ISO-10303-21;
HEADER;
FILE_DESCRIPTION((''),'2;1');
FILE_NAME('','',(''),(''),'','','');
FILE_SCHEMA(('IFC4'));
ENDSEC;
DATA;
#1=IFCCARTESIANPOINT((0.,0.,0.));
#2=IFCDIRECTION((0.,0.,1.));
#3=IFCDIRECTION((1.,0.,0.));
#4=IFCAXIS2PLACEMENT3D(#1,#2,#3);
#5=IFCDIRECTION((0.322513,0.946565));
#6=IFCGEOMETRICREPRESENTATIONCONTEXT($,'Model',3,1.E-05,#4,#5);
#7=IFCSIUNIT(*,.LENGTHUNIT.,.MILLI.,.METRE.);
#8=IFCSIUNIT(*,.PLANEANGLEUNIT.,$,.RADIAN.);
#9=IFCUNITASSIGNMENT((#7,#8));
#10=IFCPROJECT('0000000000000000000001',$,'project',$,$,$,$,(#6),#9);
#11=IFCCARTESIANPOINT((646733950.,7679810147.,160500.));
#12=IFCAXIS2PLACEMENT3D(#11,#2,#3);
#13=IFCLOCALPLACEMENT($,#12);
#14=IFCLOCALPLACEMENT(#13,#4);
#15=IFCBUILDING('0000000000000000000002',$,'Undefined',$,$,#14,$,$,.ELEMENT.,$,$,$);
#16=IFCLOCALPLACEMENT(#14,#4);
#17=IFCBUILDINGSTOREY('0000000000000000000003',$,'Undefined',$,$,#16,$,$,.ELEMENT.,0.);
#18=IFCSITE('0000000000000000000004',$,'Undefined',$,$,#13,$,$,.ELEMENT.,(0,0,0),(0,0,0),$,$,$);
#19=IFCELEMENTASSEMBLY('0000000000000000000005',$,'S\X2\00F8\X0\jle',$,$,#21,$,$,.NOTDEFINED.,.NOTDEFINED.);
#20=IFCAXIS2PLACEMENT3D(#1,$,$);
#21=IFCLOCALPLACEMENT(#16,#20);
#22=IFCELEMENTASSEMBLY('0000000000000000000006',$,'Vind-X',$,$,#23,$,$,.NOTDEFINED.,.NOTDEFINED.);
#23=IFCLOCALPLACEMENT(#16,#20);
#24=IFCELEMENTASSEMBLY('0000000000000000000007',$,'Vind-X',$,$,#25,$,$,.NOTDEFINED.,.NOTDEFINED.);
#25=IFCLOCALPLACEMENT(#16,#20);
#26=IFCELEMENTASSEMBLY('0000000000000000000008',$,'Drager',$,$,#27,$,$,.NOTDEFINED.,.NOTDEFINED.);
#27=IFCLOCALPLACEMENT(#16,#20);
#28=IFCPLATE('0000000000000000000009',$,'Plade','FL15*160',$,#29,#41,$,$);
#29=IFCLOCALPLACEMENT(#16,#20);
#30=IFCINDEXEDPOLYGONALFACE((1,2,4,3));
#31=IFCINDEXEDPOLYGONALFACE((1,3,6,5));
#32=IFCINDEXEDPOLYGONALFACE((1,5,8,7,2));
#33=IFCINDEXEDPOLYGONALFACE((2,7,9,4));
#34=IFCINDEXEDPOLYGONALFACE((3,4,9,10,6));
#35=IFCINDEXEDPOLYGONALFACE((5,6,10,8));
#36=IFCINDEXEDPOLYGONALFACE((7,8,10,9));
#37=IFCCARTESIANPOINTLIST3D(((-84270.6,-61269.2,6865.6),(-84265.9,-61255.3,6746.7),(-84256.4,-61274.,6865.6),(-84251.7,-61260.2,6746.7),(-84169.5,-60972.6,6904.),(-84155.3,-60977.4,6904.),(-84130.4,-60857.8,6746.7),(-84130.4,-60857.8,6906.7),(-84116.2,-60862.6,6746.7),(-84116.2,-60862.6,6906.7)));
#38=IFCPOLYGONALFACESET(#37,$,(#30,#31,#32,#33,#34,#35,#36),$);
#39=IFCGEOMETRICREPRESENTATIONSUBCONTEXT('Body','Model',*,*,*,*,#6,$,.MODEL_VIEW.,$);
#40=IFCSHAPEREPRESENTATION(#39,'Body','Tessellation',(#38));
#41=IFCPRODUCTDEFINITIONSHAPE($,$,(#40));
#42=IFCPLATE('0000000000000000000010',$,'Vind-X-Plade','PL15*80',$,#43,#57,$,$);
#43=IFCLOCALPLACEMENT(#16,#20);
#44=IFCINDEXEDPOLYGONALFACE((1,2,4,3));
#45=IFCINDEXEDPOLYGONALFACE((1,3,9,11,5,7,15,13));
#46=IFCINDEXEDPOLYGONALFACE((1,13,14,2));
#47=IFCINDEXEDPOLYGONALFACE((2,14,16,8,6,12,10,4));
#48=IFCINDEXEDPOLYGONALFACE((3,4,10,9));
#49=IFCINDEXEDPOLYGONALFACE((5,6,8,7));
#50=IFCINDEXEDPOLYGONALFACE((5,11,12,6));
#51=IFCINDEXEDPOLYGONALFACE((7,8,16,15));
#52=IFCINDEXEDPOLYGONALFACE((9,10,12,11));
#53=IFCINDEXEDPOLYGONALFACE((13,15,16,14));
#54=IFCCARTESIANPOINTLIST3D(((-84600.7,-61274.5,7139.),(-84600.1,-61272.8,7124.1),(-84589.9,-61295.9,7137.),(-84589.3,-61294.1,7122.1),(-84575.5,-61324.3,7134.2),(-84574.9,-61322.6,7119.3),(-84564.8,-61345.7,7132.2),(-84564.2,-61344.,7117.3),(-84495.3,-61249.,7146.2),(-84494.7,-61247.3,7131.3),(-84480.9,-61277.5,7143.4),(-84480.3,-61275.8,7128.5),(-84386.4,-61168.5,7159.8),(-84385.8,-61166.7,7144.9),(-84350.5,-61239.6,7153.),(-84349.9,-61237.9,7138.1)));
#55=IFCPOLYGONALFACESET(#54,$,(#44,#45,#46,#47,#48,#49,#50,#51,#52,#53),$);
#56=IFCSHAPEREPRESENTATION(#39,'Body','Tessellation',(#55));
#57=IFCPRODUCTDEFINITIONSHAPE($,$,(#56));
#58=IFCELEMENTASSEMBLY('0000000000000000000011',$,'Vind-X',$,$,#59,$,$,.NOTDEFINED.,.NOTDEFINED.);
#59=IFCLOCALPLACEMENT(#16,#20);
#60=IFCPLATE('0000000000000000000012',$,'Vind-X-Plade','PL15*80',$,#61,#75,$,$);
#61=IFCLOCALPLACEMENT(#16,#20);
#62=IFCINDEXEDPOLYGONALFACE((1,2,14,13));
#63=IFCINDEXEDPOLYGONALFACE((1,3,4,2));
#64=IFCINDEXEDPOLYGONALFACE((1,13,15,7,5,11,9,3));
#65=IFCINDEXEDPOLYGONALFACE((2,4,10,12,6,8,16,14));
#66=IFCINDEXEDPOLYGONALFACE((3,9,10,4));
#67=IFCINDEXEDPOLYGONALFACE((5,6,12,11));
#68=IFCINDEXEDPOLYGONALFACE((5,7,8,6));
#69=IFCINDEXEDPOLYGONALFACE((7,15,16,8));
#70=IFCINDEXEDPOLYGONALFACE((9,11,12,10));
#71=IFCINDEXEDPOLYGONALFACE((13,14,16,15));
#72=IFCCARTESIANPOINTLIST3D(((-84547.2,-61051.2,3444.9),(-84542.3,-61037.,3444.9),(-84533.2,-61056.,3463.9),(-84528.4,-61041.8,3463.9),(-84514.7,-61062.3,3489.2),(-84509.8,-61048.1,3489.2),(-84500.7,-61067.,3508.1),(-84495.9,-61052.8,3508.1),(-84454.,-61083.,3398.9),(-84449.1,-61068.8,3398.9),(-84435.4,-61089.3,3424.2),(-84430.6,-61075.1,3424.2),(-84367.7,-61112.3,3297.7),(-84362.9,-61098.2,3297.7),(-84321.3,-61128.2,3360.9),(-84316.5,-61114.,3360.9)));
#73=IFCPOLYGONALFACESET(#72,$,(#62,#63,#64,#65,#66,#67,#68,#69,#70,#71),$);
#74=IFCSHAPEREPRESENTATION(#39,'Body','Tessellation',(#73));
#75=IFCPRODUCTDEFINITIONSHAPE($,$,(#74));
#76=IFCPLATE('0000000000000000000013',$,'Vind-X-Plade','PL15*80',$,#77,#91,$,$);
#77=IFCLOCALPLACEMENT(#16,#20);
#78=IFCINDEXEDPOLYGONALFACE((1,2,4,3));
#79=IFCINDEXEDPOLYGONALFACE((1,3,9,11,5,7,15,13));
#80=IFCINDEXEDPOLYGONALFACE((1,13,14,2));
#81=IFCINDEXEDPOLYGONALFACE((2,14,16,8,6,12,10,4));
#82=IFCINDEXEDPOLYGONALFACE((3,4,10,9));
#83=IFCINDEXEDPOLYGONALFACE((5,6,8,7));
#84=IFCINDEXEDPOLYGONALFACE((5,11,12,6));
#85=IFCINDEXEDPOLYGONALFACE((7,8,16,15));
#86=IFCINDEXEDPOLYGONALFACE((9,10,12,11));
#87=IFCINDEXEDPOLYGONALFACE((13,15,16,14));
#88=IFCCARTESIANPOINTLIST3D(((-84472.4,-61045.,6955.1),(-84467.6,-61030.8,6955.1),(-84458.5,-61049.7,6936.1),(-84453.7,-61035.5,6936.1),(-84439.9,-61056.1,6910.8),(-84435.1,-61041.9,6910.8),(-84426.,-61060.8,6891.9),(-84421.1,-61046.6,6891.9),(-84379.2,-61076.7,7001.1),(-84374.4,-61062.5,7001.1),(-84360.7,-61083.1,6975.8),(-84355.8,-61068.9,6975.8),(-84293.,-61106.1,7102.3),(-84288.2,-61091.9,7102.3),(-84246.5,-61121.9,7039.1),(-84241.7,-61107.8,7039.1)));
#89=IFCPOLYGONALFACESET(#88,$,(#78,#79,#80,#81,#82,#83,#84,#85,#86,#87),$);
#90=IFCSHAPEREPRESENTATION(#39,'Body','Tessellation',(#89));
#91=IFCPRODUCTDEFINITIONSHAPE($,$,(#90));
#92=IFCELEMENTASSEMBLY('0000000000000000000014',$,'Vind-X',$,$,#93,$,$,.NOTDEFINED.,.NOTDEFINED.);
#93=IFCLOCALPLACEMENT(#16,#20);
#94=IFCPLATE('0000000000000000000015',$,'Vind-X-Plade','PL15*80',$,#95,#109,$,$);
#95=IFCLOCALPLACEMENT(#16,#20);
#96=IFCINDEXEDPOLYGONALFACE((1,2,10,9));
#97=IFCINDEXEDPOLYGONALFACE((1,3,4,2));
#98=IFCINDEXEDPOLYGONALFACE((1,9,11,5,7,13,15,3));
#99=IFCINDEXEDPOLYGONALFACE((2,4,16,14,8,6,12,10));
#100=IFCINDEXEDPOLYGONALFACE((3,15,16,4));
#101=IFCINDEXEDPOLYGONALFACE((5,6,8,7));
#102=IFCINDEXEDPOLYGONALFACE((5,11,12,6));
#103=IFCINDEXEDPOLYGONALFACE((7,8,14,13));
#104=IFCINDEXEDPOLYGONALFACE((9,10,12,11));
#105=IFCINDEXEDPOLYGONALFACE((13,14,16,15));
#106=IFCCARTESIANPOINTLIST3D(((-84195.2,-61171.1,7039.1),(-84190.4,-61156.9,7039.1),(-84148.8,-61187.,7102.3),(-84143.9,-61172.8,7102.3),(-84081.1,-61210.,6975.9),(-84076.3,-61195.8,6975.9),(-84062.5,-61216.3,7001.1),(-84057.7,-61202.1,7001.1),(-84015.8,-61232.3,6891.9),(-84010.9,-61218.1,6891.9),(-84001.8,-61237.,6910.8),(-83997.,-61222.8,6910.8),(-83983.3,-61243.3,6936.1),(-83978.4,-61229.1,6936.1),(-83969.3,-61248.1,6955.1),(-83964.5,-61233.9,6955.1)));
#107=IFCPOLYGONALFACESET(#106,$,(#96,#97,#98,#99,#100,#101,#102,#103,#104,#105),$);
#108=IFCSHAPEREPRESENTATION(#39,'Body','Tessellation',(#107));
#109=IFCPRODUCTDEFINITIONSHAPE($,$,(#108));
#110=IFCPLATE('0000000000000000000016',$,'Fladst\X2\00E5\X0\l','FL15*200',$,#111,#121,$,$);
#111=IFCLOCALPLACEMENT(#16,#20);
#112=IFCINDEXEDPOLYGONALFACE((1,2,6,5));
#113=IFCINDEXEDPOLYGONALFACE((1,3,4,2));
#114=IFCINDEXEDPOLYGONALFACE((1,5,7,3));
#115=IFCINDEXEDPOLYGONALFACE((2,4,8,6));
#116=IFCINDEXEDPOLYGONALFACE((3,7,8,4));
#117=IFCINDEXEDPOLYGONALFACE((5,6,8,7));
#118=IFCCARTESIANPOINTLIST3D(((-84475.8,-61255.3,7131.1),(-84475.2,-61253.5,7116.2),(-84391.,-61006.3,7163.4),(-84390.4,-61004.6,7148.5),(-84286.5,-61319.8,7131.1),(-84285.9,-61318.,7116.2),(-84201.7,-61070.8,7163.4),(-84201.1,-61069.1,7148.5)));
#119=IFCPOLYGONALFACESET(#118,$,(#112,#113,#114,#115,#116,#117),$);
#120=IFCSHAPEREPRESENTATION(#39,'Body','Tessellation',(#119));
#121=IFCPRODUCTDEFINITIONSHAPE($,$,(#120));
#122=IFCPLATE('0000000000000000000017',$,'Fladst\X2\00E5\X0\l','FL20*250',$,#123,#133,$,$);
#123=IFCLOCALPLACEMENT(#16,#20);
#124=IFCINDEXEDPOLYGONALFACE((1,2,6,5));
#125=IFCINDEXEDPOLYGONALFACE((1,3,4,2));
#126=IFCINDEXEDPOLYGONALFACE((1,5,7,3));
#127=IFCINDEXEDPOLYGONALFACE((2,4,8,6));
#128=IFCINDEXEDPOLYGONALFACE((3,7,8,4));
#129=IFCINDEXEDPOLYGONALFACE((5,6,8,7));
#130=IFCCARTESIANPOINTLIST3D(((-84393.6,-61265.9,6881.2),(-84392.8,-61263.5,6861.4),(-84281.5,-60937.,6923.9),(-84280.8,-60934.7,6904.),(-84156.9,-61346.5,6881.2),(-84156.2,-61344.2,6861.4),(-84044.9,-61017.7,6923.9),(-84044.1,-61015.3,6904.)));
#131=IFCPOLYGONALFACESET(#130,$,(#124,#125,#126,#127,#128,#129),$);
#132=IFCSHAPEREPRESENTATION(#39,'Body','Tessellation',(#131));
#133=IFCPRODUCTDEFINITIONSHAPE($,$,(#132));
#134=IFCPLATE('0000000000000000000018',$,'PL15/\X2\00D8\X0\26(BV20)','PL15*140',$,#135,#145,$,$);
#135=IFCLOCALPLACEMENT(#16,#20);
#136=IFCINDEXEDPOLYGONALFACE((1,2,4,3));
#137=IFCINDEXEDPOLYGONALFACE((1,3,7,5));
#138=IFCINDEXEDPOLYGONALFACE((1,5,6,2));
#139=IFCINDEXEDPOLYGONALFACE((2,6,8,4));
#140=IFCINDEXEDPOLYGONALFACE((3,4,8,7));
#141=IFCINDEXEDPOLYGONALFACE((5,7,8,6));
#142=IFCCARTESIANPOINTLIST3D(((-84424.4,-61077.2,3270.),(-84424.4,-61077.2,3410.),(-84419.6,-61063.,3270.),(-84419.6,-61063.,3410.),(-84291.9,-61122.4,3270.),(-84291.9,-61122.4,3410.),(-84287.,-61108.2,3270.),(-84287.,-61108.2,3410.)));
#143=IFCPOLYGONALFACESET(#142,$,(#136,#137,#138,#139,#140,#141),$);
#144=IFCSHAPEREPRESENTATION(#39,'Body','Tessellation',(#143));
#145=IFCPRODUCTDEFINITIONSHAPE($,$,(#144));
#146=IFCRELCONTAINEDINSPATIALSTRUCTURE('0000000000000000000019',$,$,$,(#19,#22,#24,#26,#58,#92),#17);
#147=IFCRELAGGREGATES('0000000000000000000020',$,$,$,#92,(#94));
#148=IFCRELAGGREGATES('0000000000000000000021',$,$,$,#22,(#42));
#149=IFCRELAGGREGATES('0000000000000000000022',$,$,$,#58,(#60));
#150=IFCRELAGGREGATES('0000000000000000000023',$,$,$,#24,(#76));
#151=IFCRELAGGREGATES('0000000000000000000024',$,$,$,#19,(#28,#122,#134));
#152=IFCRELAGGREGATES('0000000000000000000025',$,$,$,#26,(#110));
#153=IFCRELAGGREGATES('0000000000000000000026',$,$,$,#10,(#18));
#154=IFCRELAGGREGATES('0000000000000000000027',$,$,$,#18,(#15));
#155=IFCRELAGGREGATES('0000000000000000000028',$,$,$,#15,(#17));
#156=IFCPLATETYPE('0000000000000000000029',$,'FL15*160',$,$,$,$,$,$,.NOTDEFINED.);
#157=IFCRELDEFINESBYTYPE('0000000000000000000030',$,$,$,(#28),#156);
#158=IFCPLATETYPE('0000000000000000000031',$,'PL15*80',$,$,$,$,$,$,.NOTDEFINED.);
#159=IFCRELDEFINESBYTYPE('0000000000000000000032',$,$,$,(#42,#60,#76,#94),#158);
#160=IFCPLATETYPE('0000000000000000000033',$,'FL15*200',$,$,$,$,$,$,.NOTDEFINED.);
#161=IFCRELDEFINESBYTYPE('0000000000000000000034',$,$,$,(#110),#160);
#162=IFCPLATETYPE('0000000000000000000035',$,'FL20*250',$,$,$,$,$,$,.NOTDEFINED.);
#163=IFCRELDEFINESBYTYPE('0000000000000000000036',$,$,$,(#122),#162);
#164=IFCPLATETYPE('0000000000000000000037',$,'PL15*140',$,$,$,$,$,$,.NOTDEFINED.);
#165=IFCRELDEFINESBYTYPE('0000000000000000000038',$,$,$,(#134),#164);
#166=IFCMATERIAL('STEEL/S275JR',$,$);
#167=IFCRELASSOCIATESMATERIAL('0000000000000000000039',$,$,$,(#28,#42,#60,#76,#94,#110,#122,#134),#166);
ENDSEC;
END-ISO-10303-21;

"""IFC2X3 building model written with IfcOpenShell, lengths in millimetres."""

from ifc_helpers import new_model, si_unit, direction, frame, origin_with_axes, place, context, subcontext, project, spatial, polyline, outline, extrude, boolean, material, type_object, element, aggregate, save


model = new_model("IFC2X3")

# Units and contexts
model_context = context("Model", 3, precision=1e-05, world=origin_with_axes(), true_north=direction((0.322513, 0.946565)))
body_context = subcontext(model_context, "Body", "Model", "MODEL_VIEW")
ifc_project = project(units=[si_unit("LENGTHUNIT", "METRE", prefix="MILLI"), si_unit("PLANEANGLEUNIT", "RADIAN")], contexts=[model_context])

# Site, building, storey
site_placement = place(None, frame((646733950.0, 7679810147.0, 160500.0), z_axis=(0.0, 0.0, 1.0), x_axis=(1.0, 0.0, 0.0)))
site = spatial("IfcSite", under=ifc_project, at=site_placement, Name="Undefined", CompositionType="ELEMENT", RefLatitude=(0, 0, 0), RefLongitude=(0, 0, 0))
building_placement = place(site_placement, origin_with_axes())
building = spatial("IfcBuilding", under=site, at=building_placement, Name="Undefined", CompositionType="ELEMENT")
storey_placement = place(building_placement, origin_with_axes())
storey = spatial("IfcBuildingStorey", under=building, at=storey_placement, Name="Undefined", CompositionType="ELEMENT", Elevation=0.0)

# Element assembly
assembly_1_placement = place(storey_placement, origin_with_axes())
assembly_1 = element("IfcElementAssembly", 1, at=assembly_1_placement, inside=storey, Name="Søjle", AssemblyPlace="NOTDEFINED", PredefinedType="NOTDEFINED")

# Element assembly
assembly_2_placement = place(storey_placement, origin_with_axes())
assembly_2 = element("IfcElementAssembly", 2, at=assembly_2_placement, inside=storey, Name="Vind-X", AssemblyPlace="NOTDEFINED", PredefinedType="NOTDEFINED")

# Element assembly
assembly_3_placement = place(storey_placement, origin_with_axes())
assembly_3 = element("IfcElementAssembly", 3, at=assembly_3_placement, inside=storey, Name="Vind-X", AssemblyPlace="NOTDEFINED", PredefinedType="NOTDEFINED")

# Element assembly
ifc_material_1 = material(Name="STEEL/S275JR")
assembly_4_placement = place(storey_placement, origin_with_axes())
assembly_4 = element("IfcElementAssembly", 4, at=assembly_4_placement, inside=storey, Name="Drager", AssemblyPlace="NOTDEFINED", PredefinedType="NOTDEFINED")

# Plates
plate_type_1 = type_object("IfcPlateType", Name="FL15*160", PredefinedType="NOTDEFINED")
plate_1_placement = place(assembly_1_placement, frame((-84263.5, -61271.6, 6865.6), z_axis=(0.946565, -0.322513, 0.0), x_axis=(0.039304, 0.115357, -0.992546)))
plate_1 = element("IfcPlate", 5, at=plate_1_placement, type_object=plate_type_1, material=ifc_material_1, Name="Plade", Description="FL15*160", context=body_context, shape_type="SweptSolid", body=[
    extrude(outline(polyline([(0.0, 0.0), (119.8, 0.0), (171.0, 416.9), (12.2, 436.4), (0.0, 315.6), (0.0, 0.0)])), frame((0.0, 0.0, -7.5), z_axis=(0.0, 0.0, 1.0), x_axis=(1.0, 0.0, 0.0)), (0.0, 0.0, 1.0), 15.0),
])
plate_type_2 = type_object("IfcPlateType", Name="PL15*80", PredefinedType="NOTDEFINED")
plate_2_placement = place(assembly_2_placement, frame((-84350.2, -61238.8, 7145.5), z_axis=(-0.039304, -0.115357, 0.992546), x_axis=(-0.448662, 0.88959, 0.085625)))
plate_2 = element("IfcPlate", 6, at=plate_2_placement, type_object=plate_type_2, material=ifc_material_1, Name="Vind-X-Plade", Description="PL15*80", context=body_context, shape_type="CSG", body=[
    boolean("DIFFERENCE", extrude(outline(polyline([(0.0, 0.0), (80.0, 0.0), (80.0, 240.0), (0.0, 240.0), (0.0, 0.0)])), frame((0.0, 0.0, -7.5), z_axis=(0.0, 0.0, 1.0), x_axis=(1.0, 0.0, 0.0)), (0.0, 0.0, 1.0), 15.0), extrude(outline(polyline([(0.0, 0.0), (106.0, 0.0), (106.0, 32.0), (0.0, 32.0), (0.0, 0.0)])), frame((56.0, 240.0, 8.5), z_axis=(0.0, 0.0, -1.0), x_axis=(0.0, -1.0, 0.0)), (0.0, 0.0, 1.0), 17.0)),
])

# Element assembly, plate
assembly_5_placement = place(storey_placement, origin_with_axes())
assembly_5 = element("IfcElementAssembly", 7, at=assembly_5_placement, inside=storey, Name="Vind-X", AssemblyPlace="NOTDEFINED", PredefinedType="NOTDEFINED")
plate_3_placement = place(assembly_5_placement, frame((-84365.3, -61105.2, 3297.7), z_axis=(-0.322513, -0.946565, 0.0), x_axis=(0.580575, -0.197813, 0.789812)))
plate_3 = element("IfcPlate", 8, at=plate_3_placement, type_object=plate_type_2, material=ifc_material_1, Name="Vind-X-Plade", Description="PL15*80", context=body_context, shape_type="CSG", body=[
    boolean("DIFFERENCE", extrude(outline(polyline([(0.0, 0.0), (80.0, 0.0), (80.0, 240.0), (0.0, 240.0), (0.0, 0.0)])), frame((0.0, 0.0, -7.5), z_axis=(0.0, 0.0, 1.0), x_axis=(1.0, 0.0, 0.0)), (0.0, 0.0, 1.0), 15.0), extrude(outline(polyline([(0.0, 0.0), (106.0, 0.0), (106.0, 32.0), (0.0, 32.0), (0.0, 0.0)])), frame((56.0, 240.0, 8.5), z_axis=(0.0, 0.0, -1.0), x_axis=(0.0, -1.0, 0.0)), (0.0, 0.0, 1.0), 17.0)),
])

# Plate
plate_4_placement = place(assembly_3_placement, frame((-84244.1, -61114.8, 7039.1), z_axis=(-0.322513, -0.946565, 0.0), x_axis=(-0.580575, 0.197813, 0.789812)))
plate_4 = element("IfcPlate", 9, at=plate_4_placement, type_object=plate_type_2, material=ifc_material_1, Name="Vind-X-Plade", Description="PL15*80", context=body_context, shape_type="CSG", body=[
    boolean("DIFFERENCE", extrude(outline(polyline([(0.0, 0.0), (80.0, 0.0), (80.0, 240.0), (0.0, 240.0), (0.0, 0.0)])), frame((0.0, 0.0, -7.5), z_axis=(0.0, 0.0, 1.0), x_axis=(1.0, 0.0, 0.0)), (0.0, 0.0, 1.0), 15.0), extrude(outline(polyline([(0.0, 0.0), (106.0, 0.0), (106.0, 32.0), (0.0, 32.0), (0.0, 0.0)])), frame((56.0, 240.0, 8.5), z_axis=(0.0, 0.0, -1.0), x_axis=(0.0, -1.0, 0.0)), (0.0, 0.0, 1.0), 17.0)),
])

# Element assembly, plate
assembly_6_placement = place(storey_placement, origin_with_axes())
assembly_6 = element("IfcElementAssembly", 10, at=assembly_6_placement, inside=storey, Name="Vind-X", AssemblyPlace="NOTDEFINED", PredefinedType="NOTDEFINED")
plate_5_placement = place(assembly_6_placement, frame((-84192.8, -61164.0, 7039.1), z_axis=(0.322513, 0.946565, 0.0), x_axis=(0.580542, -0.197802, 0.789839)))
plate_5 = element("IfcPlate", 11, at=plate_5_placement, type_object=plate_type_2, material=ifc_material_1, Name="Vind-X-Plade", Description="PL15*80", context=body_context, shape_type="CSG", body=[
    boolean("DIFFERENCE", extrude(outline(polyline([(0.0, 0.0), (80.0, 0.0), (80.0, 240.0), (0.0, 240.0), (0.0, 0.0)])), frame((0.0, 0.0, -7.5), z_axis=(0.0, 0.0, 1.0), x_axis=(1.0, 0.0, 0.0)), (0.0, 0.0, 1.0), 15.0), extrude(outline(polyline([(0.0, 0.0), (106.0, 0.0), (106.0, 32.0), (0.0, 32.0), (0.0, 0.0)])), frame((56.0, 240.0, 8.5), z_axis=(0.0, 0.0, -1.0), x_axis=(0.0, -1.0, 0.0)), (0.0, 0.0, 1.0), 17.0)),
])
aggregate(assembly_6, [plate_5])

# Plates
plate_type_3 = type_object("IfcPlateType", Name="FL15*200", PredefinedType="NOTDEFINED")
plate_6_placement = place(assembly_4_placement, frame((-84286.2, -61318.9, 7123.6), z_axis=(-0.039304, -0.115357, 0.992546), x_axis=(0.320109, 0.93951, 0.121869)))
plate_6 = element("IfcPlate", 12, at=plate_6_placement, type_object=plate_type_3, material=ifc_material_1, Name="Fladstål", Description="FL15*200", context=body_context, shape_type="SweptSolid", body=[
    extrude(outline(polyline([(0.0, 0.0), (265.0, 0.0), (265.0, 200.0), (0.0, 200.0), (0.0, 0.0)])), frame((0.0, 0.0, -7.5), z_axis=(0.0, 0.0, 1.0), x_axis=(1.0, 0.0, 0.0)), (0.0, 0.0, 1.0), 15.0),
])
plate_type_4 = type_object("IfcPlateType", Name="FL20*250", PredefinedType="NOTDEFINED")
plate_7_placement = place(assembly_1_placement, frame((-84274.9, -61305.0, 6871.3), z_axis=(0.039304, 0.115357, -0.992546), x_axis=(0.320109, 0.93951, 0.121869)))
plate_7 = element("IfcPlate", 13, at=plate_7_placement, type_object=plate_type_4, material=ifc_material_1, Name="Fladstål", Description="FL20*250", context=body_context, shape_type="SweptSolid", body=[
    extrude(outline(polyline([(0.0, -125.0), (0.0, 125.0), (350.0, 125.0), (350.0, -125.0), (0.0, -125.0)])), frame((0.0, 0.0, -10.0), z_axis=(0.0, 0.0, 1.0), x_axis=(1.0, 0.0, 0.0)), (0.0, 0.0, 1.0), 20.0),
])
plate_type_5 = type_object("IfcPlateType", Name="PL15*140", PredefinedType="NOTDEFINED")
plate_8_placement = place(assembly_1_placement, frame((-84422.0, -61070.1, 3270.0), z_axis=(-0.322513, -0.946565, 0.0), x_axis=(0.946565, -0.322513, 0.0)))
plate_8 = element("IfcPlate", 14, at=plate_8_placement, type_object=plate_type_5, material=ifc_material_1, Name="PL15/Ø26(BV20)", Description="PL15*140", context=body_context, shape_type="SweptSolid", body=[
    extrude(outline(polyline([(0.0, 0.0), (140.0, 0.0), (140.0, 140.0), (0.0, 140.0), (0.0, 0.0)])), frame((0.0, 0.0, -7.5), z_axis=(0.0, 0.0, 1.0), x_axis=(1.0, 0.0, 0.0)), (0.0, 0.0, 1.0), 15.0),
])

aggregate(assembly_2, [plate_2])
aggregate(assembly_5, [plate_3])
aggregate(assembly_3, [plate_4])
aggregate(assembly_1, [plate_1, plate_7, plate_8])
aggregate(assembly_4, [plate_6])

save(model, "model.ifc")
